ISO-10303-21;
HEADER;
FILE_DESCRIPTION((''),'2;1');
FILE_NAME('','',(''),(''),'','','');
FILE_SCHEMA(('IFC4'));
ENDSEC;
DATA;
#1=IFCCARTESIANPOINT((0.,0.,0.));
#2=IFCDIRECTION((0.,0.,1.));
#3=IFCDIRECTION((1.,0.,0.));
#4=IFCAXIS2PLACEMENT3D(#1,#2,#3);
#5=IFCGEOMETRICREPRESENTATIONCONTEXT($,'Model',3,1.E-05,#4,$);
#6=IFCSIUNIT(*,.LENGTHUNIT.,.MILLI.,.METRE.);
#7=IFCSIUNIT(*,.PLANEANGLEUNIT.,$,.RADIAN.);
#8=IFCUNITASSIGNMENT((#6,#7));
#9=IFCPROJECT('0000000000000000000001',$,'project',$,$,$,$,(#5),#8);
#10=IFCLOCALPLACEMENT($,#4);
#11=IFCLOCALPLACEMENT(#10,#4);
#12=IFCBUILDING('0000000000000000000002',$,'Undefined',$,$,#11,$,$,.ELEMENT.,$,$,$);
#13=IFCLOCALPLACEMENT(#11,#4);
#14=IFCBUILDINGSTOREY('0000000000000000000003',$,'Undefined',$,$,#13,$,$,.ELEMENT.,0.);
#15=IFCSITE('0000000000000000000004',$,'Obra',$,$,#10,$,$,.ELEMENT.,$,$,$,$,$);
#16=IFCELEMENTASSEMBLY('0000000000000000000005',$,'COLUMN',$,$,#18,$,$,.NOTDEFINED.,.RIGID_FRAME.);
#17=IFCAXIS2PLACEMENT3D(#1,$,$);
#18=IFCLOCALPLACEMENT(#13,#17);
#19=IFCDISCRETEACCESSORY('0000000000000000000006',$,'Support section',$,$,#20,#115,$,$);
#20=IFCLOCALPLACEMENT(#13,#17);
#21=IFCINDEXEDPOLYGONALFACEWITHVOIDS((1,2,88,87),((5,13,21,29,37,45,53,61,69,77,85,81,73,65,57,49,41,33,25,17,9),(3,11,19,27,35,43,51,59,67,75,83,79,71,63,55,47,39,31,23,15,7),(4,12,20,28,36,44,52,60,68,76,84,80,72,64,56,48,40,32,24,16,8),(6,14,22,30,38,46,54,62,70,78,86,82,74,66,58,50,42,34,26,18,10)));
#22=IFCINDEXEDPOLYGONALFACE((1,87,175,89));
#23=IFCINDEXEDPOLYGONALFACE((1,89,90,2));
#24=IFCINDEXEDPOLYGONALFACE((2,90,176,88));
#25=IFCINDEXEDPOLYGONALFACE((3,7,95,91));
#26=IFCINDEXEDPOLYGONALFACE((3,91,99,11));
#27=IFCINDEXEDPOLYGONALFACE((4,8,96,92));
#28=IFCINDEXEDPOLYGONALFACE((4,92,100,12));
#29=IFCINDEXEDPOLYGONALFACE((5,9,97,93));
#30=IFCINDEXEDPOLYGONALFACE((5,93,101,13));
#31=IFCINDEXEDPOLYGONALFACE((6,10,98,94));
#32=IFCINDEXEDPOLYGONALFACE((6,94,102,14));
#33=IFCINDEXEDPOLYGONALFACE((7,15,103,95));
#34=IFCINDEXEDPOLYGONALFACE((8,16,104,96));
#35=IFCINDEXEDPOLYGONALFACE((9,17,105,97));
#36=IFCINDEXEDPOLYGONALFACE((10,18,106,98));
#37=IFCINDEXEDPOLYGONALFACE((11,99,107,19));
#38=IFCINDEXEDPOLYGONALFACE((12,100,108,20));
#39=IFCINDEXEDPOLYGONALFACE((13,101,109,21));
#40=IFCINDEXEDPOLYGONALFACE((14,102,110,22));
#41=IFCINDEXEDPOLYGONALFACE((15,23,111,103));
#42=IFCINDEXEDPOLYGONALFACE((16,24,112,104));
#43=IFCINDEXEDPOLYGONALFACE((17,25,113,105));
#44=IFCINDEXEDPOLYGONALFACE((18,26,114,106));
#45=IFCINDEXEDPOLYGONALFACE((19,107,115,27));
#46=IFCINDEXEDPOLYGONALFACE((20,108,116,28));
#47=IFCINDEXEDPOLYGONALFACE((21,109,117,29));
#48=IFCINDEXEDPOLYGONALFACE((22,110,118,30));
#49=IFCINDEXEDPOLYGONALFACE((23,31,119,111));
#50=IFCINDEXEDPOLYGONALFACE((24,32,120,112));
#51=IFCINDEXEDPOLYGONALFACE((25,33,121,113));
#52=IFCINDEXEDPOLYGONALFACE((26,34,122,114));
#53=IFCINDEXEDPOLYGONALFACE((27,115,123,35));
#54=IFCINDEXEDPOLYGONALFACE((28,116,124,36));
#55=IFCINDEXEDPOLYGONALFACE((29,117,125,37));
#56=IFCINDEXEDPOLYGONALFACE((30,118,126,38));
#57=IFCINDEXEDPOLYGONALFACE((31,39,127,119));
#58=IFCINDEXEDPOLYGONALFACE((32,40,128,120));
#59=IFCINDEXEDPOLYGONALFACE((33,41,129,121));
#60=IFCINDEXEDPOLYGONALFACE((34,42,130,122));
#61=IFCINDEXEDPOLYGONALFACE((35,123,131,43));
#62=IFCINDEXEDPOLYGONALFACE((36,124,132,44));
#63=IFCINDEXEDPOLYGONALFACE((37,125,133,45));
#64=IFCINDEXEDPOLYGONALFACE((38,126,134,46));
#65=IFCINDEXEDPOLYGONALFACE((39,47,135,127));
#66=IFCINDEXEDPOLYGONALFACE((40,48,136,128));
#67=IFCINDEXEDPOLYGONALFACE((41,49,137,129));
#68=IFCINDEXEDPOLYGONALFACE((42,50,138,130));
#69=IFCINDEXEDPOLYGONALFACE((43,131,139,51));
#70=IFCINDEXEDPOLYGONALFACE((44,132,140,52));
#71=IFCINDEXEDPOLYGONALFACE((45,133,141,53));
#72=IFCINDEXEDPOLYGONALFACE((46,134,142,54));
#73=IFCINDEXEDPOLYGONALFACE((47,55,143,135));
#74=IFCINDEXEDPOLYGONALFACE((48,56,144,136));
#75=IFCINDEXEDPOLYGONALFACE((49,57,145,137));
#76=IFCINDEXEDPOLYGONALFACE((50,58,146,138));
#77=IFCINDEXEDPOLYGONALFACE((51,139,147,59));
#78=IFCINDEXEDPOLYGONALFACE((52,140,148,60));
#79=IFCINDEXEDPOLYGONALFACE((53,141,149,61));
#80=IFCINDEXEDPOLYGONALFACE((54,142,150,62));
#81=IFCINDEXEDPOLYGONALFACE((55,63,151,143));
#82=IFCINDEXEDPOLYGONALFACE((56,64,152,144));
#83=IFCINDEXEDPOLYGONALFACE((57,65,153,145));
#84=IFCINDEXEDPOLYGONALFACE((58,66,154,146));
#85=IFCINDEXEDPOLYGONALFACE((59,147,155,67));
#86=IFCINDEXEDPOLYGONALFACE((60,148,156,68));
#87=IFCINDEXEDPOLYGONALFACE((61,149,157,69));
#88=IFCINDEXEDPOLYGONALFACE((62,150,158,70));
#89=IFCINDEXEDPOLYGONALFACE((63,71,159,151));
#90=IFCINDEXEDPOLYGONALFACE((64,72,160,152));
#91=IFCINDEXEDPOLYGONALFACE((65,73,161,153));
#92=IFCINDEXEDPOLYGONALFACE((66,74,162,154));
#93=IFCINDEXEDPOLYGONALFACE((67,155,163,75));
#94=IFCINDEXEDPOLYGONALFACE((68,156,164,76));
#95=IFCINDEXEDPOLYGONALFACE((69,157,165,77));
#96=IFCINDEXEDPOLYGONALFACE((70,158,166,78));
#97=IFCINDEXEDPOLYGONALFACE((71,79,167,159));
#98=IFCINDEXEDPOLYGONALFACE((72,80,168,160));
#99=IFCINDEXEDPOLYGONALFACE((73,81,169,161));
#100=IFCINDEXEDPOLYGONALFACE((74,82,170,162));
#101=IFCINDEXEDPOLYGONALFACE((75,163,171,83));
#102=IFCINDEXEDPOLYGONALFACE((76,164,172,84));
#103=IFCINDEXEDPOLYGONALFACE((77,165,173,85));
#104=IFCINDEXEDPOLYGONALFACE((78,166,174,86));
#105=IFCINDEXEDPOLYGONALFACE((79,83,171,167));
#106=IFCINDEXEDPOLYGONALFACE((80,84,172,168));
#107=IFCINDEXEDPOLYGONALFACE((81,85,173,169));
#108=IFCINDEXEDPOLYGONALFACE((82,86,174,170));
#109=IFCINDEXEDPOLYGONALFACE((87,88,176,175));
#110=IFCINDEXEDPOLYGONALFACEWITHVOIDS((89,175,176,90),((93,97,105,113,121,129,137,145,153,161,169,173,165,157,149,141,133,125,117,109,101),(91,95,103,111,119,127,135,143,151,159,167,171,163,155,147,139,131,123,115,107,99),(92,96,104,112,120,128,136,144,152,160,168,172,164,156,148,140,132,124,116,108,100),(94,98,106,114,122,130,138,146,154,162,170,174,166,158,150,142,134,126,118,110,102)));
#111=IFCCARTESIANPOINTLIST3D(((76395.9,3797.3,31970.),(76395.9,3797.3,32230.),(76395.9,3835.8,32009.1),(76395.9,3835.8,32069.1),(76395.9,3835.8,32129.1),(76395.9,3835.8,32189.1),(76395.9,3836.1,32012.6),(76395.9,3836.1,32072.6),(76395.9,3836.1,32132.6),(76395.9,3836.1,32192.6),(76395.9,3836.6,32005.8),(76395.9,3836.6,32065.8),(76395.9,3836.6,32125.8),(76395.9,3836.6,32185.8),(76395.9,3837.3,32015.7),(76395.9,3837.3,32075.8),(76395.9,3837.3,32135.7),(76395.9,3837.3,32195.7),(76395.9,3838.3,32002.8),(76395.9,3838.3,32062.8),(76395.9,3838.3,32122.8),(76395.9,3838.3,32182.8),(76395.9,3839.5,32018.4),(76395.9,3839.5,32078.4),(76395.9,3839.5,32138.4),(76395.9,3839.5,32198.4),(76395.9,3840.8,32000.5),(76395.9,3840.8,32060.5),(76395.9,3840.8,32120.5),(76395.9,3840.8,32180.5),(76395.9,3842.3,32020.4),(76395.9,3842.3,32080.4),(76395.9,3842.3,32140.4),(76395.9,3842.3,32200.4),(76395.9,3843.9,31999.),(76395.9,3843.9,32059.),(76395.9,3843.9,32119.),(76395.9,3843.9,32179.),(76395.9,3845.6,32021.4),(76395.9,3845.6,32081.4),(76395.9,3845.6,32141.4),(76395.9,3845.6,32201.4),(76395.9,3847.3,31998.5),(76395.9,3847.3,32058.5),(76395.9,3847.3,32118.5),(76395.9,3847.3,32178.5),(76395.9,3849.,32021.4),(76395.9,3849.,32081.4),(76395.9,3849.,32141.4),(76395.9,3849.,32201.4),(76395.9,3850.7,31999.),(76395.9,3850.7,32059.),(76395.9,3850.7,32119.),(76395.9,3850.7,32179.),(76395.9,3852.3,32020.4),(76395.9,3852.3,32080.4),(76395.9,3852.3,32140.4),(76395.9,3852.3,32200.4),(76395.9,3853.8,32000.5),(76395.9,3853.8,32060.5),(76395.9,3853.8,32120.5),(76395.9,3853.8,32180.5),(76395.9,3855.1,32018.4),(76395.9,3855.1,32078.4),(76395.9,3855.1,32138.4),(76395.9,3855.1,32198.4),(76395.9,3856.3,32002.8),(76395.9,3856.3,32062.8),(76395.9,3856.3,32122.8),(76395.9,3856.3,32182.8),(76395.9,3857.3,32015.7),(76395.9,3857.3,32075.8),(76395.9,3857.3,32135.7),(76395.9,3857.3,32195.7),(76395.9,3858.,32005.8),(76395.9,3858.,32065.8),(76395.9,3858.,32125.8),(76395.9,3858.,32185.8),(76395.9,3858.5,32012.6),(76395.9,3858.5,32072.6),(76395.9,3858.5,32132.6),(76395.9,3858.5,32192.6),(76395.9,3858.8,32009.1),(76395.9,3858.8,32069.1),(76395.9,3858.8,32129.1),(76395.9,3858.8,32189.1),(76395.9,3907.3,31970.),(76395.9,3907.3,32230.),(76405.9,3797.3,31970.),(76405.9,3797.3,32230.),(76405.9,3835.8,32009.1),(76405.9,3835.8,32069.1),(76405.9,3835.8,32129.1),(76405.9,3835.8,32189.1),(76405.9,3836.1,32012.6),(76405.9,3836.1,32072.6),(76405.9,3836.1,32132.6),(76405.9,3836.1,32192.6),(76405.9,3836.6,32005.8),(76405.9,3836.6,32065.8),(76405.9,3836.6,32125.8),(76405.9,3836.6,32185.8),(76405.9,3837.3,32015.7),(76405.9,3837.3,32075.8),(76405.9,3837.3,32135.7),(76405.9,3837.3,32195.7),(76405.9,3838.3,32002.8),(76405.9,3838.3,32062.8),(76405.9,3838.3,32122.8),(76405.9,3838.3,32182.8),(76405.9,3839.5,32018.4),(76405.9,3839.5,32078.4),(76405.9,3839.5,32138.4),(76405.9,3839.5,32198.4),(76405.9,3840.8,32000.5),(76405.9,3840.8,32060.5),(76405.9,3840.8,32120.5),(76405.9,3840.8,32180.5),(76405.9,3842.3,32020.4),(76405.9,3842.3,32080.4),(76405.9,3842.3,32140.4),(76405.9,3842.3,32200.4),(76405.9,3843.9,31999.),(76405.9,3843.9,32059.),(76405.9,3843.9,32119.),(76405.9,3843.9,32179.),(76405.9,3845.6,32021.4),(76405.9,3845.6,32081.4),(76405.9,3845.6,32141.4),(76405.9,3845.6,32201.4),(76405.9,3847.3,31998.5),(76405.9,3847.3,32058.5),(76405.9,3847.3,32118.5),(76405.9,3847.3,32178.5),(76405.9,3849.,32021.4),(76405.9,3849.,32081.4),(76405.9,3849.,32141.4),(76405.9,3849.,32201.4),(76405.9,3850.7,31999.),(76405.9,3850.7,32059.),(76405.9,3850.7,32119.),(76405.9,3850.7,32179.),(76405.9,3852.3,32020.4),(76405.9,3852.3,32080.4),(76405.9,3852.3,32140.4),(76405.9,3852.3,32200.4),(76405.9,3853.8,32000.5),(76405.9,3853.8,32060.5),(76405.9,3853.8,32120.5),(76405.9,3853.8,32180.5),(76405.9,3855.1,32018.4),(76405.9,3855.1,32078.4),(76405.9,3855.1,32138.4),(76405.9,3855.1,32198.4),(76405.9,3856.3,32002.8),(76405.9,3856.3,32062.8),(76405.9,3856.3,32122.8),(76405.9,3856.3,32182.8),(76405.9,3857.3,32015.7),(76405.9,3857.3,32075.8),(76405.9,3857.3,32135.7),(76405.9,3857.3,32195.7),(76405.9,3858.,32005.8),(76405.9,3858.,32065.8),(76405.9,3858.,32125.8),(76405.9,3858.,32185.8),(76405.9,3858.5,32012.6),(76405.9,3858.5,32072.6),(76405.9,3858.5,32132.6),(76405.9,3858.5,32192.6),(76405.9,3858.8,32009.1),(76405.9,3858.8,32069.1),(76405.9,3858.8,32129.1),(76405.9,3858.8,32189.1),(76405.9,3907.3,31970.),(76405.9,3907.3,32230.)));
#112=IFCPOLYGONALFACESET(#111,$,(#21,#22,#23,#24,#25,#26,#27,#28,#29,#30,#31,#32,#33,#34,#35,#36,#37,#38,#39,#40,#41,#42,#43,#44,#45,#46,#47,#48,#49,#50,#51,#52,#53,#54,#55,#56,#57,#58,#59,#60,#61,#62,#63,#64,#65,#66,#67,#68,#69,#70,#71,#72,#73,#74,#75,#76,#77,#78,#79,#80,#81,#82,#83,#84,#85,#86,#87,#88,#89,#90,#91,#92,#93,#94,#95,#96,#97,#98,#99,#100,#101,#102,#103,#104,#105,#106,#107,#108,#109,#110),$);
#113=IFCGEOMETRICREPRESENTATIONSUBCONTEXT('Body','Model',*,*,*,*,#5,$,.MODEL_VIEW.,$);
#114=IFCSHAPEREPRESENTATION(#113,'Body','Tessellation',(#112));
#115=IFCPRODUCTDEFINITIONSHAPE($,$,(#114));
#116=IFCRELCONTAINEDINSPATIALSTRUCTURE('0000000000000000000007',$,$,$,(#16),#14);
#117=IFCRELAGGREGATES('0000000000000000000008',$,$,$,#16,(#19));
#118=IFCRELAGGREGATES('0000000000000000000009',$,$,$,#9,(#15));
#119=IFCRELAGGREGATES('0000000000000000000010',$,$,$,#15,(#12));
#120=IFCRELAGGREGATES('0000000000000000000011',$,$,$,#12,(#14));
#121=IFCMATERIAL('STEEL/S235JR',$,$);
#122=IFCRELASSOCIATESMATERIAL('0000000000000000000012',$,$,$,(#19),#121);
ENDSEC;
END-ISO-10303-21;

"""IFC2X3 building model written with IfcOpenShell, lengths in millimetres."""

from ifc_helpers import new_model, si_unit, frame, origin_with_axes, origin_2d_with_axis, place, context, subcontext, project, spatial, rectangle, circle, extrude, source, transform, mapped, material, element, aggregate, save


model = new_model("IFC2X3")

# Units and contexts
model_context = context("Model", 3, precision=1e-05, world=origin_with_axes())
body_context = subcontext(model_context, "Body", "Model", "MODEL_VIEW")
ifc_project = project(units=[si_unit("LENGTHUNIT", "METRE", prefix="MILLI"), si_unit("PLANEANGLEUNIT", "RADIAN")], contexts=[model_context])

# Site, building, storey
site_placement = place(None, origin_with_axes())
site = spatial("IfcSite", under=ifc_project, at=site_placement, Name="Obra", CompositionType="ELEMENT")
building_placement = place(site_placement, origin_with_axes())
building = spatial("IfcBuilding", under=site, at=building_placement, Name="Undefined", CompositionType="ELEMENT")
storey_placement = place(building_placement, origin_with_axes())
storey = spatial("IfcBuildingStorey", under=building, at=storey_placement, Name="Undefined", CompositionType="ELEMENT", Elevation=0.0)

# Element assembly
assembly_1_placement = place(storey_placement, origin_with_axes())
assembly_1 = element("IfcElementAssembly", 1, at=assembly_1_placement, inside=storey, Name="COLUMN", AssemblyPlace="NOTDEFINED", PredefinedType="RIGID_FRAME")
ifc_material_1 = material(Name="STEEL/S235JR")

# Discrete accessory, opening
discrete_accessory_1_placement = place(assembly_1_placement, frame((76400.9, 3852.3, 31970.0), z_axis=(0.0, 0.0, 1.0), x_axis=(0.0, 1.0, 0.0)))
discrete_accessory_1 = element("IfcDiscreteAccessory", 2, at=discrete_accessory_1_placement, material=ifc_material_1, Name="Support section", context=body_context, shape_type="SweptSolid", body=[
    extrude(rectangle(XDim=10.0, YDim=110.0, at=origin_2d_with_axis()), frame((0.0, 0.0, 260.0), z_axis=(0.0, 0.0, -1.0), x_axis=(0.0, 1.0, 0.0)), (0.0, 0.0, 1.0), 260.0),
])
shared_shape_1 = source(origin_with_axes(), body_context, "Body", "SweptSolid", [
    extrude(circle(Radius=11.5, at=origin_2d_with_axis()), frame((0.0, -14.4, 0.0), z_axis=(0.0, 1.0, 0.0), x_axis=(1.0, 0.0, 0.0)), (0.0, 0.0, 1.0), 10.2),
])
opening_1_placement = place(assembly_1_placement, frame((76410.2, 3897.3, 32300.0), z_axis=(0.0, -1.0, 0.0), x_axis=(0.0, 0.0, -1.0)))
element("IfcOpeningElement", 3, at=opening_1_placement, cuts=discrete_accessory_1, ObjectType="Opening", context=body_context, shape_type="MappedRepresentation", body=[
    mapped(shared_shape_1, transform((110.0, 0.0, 50.0))),
    mapped(shared_shape_1, transform((170.0, 0.0, 50.0))),
    mapped(shared_shape_1, transform((230.0, 0.0, 50.0))),
    mapped(shared_shape_1, transform((290.0, 0.0, 50.0))),
])
aggregate(assembly_1, [discrete_accessory_1])

save(model, "model.ifc")
